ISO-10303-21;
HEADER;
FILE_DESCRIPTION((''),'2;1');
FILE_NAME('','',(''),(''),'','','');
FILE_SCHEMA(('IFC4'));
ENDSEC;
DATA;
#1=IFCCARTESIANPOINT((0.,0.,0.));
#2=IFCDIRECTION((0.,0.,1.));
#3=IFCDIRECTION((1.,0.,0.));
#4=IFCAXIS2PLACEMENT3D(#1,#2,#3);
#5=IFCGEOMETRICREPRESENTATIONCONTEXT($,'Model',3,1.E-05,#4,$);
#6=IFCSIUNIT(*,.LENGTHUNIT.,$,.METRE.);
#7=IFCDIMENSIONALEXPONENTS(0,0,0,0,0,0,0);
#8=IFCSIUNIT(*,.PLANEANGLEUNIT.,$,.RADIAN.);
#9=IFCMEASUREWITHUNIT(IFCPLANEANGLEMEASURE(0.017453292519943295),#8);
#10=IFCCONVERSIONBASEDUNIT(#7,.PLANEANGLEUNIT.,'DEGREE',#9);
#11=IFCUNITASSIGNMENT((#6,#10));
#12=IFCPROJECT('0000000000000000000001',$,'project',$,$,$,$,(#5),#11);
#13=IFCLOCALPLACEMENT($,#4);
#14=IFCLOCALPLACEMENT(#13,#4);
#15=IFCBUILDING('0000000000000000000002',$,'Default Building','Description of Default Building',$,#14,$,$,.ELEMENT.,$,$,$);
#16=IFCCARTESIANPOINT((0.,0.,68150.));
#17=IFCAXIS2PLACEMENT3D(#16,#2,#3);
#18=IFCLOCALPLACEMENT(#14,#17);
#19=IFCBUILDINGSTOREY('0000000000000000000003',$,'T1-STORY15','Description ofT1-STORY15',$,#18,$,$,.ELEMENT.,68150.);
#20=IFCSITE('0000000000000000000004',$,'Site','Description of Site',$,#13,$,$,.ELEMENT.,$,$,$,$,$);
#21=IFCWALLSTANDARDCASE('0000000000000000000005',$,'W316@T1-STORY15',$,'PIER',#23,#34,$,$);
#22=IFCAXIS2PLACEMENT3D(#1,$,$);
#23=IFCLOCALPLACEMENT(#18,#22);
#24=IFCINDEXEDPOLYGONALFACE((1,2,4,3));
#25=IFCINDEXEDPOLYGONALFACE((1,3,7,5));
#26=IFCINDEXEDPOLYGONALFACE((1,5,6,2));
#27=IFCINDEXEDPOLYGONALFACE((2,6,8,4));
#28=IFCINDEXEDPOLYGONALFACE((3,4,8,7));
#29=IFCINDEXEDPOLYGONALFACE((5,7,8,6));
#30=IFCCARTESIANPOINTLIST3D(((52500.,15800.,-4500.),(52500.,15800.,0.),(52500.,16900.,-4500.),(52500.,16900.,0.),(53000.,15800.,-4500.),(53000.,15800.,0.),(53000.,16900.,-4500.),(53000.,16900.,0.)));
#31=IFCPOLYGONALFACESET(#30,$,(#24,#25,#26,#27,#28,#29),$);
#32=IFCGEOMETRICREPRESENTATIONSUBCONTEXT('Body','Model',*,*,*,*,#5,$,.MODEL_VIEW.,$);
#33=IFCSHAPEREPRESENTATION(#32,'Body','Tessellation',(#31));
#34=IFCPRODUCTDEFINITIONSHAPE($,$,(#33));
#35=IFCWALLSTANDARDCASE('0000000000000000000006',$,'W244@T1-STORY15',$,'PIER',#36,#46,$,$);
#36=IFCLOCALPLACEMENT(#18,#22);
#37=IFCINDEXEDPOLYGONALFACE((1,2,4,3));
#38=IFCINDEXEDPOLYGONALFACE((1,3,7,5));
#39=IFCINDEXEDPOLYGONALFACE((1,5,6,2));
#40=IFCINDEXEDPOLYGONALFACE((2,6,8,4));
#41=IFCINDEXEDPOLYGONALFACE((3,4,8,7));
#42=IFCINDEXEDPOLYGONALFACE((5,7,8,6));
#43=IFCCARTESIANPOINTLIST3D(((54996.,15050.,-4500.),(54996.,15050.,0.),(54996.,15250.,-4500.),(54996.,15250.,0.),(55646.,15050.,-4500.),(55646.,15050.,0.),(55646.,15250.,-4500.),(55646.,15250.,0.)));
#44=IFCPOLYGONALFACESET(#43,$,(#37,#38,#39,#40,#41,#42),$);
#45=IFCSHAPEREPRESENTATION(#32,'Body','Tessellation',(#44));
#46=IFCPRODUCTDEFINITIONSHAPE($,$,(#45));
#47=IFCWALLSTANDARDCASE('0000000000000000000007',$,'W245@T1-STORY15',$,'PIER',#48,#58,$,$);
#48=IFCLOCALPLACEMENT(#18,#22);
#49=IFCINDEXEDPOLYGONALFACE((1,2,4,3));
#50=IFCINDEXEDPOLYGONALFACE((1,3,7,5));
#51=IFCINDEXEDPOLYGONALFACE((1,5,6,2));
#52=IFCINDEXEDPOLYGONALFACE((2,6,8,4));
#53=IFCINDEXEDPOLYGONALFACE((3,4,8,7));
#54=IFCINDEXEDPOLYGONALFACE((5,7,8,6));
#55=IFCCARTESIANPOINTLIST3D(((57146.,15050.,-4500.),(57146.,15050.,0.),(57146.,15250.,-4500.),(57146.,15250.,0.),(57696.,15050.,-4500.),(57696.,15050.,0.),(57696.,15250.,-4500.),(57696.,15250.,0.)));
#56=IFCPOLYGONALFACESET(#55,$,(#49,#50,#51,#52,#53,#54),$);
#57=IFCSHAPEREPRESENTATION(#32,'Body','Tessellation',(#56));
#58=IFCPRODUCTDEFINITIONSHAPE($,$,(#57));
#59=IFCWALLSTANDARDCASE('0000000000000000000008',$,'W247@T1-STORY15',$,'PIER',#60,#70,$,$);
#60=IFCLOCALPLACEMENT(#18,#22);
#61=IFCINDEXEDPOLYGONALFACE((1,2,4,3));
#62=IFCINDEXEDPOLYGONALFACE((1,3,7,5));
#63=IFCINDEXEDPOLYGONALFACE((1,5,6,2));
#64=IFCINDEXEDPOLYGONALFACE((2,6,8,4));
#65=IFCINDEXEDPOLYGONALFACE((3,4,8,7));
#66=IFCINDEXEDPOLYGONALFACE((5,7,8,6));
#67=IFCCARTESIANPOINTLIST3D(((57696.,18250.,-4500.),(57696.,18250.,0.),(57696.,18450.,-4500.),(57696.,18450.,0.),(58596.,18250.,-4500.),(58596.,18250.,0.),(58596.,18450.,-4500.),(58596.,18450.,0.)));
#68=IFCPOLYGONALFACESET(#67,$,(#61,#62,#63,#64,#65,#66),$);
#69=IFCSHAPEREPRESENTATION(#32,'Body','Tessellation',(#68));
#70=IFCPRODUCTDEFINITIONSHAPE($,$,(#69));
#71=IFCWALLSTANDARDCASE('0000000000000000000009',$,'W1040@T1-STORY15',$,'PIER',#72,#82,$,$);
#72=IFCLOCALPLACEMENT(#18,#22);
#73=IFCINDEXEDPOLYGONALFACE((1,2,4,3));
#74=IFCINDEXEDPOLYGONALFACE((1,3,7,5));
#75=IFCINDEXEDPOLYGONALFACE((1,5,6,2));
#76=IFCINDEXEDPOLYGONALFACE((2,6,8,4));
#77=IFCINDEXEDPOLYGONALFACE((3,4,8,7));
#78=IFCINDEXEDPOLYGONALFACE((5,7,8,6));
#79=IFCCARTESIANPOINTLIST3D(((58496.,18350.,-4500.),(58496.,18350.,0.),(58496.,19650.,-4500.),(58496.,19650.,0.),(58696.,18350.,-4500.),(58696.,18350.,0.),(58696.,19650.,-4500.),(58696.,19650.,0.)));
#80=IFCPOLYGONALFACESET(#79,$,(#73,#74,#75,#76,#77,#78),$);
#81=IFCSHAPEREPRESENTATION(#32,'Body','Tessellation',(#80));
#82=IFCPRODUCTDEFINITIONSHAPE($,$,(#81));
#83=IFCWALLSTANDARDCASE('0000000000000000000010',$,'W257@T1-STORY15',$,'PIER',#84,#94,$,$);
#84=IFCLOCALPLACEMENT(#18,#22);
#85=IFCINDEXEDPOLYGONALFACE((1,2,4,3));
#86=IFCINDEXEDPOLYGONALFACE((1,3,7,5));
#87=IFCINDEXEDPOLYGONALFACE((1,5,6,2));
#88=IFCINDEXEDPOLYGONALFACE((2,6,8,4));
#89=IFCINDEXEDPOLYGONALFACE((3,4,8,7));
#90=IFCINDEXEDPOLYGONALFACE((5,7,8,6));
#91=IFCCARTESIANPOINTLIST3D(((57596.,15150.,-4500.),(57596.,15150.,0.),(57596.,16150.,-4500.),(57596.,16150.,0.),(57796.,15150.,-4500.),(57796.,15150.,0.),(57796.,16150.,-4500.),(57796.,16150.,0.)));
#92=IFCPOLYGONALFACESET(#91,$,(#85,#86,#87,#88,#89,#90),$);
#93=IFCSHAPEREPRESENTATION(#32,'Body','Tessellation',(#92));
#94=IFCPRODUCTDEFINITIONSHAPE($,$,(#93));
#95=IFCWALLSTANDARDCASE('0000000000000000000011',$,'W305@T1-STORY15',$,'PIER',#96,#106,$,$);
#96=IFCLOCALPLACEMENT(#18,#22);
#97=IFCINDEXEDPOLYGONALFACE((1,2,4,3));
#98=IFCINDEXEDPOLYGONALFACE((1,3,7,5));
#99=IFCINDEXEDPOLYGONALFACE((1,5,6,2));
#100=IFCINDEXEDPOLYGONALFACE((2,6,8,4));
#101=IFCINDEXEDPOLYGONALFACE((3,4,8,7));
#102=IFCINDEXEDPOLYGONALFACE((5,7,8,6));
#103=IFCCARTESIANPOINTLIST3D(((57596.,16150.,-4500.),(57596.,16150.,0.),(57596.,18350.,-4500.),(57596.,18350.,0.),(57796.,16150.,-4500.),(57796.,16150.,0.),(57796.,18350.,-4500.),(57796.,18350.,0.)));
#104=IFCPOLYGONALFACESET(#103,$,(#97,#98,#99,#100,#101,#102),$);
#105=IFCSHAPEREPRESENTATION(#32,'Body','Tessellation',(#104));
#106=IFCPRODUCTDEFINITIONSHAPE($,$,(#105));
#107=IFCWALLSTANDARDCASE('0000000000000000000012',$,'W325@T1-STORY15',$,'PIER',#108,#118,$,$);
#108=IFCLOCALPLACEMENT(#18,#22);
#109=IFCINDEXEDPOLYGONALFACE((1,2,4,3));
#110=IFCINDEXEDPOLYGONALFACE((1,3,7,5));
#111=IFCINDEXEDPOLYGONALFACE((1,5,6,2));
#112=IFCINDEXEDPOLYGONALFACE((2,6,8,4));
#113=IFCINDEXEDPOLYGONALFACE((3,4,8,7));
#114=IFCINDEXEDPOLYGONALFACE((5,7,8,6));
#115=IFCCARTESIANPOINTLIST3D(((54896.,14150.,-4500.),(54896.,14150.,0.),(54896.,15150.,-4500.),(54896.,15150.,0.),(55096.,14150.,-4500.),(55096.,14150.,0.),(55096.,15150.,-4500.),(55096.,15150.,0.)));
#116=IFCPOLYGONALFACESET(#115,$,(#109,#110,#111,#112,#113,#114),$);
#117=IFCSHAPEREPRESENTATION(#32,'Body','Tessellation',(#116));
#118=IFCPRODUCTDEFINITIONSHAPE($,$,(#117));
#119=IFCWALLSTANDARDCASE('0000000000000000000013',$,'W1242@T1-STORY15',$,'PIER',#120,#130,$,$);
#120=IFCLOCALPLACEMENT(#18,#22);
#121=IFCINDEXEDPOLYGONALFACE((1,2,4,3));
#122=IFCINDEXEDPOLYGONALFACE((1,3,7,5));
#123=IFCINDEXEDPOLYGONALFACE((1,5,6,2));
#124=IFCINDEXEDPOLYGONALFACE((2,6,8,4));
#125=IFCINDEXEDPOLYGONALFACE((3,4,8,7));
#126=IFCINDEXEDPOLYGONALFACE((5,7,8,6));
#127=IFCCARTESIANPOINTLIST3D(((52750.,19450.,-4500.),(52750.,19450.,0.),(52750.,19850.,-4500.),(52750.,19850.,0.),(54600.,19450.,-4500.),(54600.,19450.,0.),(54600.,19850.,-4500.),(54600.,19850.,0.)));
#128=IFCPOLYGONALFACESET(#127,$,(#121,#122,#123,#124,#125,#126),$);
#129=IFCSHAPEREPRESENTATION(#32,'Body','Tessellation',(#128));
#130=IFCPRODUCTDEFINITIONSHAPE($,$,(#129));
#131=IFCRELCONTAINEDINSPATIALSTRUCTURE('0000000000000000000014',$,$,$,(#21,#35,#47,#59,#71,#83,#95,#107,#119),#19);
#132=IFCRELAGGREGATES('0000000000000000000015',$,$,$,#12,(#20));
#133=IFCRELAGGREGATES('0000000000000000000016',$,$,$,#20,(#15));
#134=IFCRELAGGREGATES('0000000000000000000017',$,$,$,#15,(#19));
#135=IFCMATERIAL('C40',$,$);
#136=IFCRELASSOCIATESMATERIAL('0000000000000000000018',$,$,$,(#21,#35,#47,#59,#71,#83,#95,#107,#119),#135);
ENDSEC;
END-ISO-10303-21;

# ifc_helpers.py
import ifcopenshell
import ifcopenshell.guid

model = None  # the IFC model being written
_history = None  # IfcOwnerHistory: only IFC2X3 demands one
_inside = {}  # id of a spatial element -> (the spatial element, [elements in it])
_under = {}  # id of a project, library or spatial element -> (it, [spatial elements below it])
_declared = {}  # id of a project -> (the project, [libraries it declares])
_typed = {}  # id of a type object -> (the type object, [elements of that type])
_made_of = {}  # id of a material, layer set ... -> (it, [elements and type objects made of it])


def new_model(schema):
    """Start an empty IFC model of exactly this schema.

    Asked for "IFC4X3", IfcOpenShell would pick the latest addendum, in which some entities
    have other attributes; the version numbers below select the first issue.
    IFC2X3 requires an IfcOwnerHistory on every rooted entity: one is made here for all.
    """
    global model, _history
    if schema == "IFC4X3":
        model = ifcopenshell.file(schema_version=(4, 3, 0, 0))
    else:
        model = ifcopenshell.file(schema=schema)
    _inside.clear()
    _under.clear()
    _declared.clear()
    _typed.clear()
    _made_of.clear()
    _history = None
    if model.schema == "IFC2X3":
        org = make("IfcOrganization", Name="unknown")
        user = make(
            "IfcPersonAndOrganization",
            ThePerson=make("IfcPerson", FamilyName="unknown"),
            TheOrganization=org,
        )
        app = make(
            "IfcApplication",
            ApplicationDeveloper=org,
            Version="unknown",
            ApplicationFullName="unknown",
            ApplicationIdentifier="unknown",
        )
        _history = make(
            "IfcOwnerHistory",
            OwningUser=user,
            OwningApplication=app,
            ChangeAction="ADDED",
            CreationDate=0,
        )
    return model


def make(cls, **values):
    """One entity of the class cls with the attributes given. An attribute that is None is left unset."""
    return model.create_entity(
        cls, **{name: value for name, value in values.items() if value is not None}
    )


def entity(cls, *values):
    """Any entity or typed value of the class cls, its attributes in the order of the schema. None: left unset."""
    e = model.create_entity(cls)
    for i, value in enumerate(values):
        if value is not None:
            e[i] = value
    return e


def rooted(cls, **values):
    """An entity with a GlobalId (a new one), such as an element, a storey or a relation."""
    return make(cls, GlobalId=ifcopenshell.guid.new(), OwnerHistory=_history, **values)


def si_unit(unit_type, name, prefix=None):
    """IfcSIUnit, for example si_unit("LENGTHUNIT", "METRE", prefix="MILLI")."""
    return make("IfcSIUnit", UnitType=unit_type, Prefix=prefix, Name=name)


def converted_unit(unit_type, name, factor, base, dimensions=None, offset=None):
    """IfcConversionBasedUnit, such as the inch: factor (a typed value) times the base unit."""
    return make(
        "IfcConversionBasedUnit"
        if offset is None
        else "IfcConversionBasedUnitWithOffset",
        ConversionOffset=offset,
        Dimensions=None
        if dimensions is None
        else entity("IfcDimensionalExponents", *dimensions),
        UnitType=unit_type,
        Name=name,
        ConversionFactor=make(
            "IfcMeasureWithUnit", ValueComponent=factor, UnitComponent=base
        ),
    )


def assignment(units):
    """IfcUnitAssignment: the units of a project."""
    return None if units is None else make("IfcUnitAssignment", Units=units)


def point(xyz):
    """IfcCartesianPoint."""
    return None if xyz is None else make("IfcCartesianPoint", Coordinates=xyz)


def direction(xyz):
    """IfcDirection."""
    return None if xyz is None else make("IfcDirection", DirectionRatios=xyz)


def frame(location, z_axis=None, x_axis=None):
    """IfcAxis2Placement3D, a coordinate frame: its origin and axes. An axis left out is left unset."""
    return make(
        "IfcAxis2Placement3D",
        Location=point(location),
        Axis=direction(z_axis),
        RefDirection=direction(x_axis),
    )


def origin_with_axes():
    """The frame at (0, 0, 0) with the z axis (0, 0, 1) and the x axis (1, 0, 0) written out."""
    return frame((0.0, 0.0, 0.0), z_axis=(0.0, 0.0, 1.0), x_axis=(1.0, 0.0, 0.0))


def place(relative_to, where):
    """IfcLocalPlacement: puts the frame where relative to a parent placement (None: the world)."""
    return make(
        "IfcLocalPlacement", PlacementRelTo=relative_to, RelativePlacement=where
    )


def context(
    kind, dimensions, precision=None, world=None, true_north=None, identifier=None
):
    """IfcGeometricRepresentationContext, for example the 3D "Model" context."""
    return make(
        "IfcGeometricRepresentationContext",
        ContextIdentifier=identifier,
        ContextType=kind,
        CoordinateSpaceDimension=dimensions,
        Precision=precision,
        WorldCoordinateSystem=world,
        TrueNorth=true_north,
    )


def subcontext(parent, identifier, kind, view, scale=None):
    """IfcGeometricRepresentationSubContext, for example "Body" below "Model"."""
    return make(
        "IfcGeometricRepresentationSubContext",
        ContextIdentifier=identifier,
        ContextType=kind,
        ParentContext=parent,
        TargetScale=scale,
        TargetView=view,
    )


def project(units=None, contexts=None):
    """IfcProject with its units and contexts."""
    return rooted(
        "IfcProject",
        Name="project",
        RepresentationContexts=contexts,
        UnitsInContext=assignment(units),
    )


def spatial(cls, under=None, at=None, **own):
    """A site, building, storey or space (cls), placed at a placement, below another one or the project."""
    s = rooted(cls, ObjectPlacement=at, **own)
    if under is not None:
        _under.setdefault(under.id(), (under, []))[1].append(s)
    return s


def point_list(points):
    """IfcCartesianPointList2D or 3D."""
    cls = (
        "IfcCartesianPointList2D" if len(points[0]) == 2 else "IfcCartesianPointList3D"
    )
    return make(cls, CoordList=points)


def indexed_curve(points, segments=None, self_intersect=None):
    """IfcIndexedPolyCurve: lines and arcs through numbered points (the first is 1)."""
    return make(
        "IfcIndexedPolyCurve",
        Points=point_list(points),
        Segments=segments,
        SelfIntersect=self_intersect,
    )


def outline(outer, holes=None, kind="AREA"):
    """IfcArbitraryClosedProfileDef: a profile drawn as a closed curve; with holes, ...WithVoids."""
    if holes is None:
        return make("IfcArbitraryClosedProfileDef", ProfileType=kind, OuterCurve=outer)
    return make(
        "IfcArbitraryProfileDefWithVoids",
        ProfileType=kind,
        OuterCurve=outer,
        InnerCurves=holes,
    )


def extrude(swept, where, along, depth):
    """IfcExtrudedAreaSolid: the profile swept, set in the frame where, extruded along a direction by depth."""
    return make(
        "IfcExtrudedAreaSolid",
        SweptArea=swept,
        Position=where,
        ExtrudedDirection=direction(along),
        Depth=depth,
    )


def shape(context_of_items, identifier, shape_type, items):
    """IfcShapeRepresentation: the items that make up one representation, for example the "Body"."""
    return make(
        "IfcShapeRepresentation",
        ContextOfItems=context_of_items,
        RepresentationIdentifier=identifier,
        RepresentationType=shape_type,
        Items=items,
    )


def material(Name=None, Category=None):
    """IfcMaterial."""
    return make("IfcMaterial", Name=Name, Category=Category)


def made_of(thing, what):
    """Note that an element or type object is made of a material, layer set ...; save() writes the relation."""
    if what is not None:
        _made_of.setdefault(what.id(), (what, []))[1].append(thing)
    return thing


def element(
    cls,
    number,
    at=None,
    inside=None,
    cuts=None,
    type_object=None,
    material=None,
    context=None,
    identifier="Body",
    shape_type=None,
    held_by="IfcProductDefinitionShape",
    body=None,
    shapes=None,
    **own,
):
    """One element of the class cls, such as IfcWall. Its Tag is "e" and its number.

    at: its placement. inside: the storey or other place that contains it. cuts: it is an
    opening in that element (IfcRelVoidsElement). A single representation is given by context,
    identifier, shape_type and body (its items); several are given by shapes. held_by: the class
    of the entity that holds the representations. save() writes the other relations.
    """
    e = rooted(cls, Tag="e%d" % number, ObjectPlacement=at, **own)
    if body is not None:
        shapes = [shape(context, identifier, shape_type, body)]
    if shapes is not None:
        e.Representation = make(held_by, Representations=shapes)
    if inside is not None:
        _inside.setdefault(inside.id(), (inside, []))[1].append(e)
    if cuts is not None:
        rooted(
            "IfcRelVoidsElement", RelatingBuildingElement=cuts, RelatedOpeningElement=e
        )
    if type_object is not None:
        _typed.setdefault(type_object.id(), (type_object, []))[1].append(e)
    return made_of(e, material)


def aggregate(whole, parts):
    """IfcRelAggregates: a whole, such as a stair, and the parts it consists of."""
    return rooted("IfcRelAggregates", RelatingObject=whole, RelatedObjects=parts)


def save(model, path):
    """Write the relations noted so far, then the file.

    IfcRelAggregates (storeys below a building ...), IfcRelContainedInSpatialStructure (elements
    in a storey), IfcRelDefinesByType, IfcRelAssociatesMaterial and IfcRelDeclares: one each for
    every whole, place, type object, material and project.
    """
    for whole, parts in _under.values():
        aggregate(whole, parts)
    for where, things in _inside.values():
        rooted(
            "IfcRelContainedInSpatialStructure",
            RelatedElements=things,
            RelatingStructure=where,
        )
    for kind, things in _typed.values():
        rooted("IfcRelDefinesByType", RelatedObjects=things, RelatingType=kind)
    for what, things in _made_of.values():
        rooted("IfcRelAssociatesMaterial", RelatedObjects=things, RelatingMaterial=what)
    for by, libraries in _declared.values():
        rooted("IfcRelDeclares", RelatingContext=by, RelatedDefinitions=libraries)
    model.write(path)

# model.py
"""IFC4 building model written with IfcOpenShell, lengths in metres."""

from ifc_helpers import new_model, entity, si_unit, converted_unit, frame, origin_with_axes, place, context, subcontext, project, spatial, indexed_curve, outline, extrude, material, element, save


model = new_model("IFC4")

# Units and contexts
model_context = context("Model", 3, precision=1e-05, world=origin_with_axes())
body_context = subcontext(model_context, "Body", "Model", "MODEL_VIEW")
ifc_project = project(units=[si_unit("LENGTHUNIT", "METRE"), converted_unit("PLANEANGLEUNIT", "DEGREE", entity("IfcPlaneAngleMeasure", 0.017453292519943295), si_unit("PLANEANGLEUNIT", "RADIAN"), dimensions=[0, 0, 0, 0, 0, 0, 0])], contexts=[model_context])

# Site, building, storey
site_placement = place(None, origin_with_axes())
site = spatial("IfcSite", under=ifc_project, at=site_placement, Name="Site", Description="Description of Site", CompositionType="ELEMENT")
building_placement = place(site_placement, origin_with_axes())
building = spatial("IfcBuilding", under=site, at=building_placement, Name="Default Building", Description="Description of Default Building", CompositionType="ELEMENT")
storey_placement = place(building_placement, frame((0.0, 0.0, 68150.0), z_axis=(0.0, 0.0, 1.0), x_axis=(1.0, 0.0, 0.0)))
storey = spatial("IfcBuildingStorey", under=building, at=storey_placement, Name="T1-STORY15", Description="Description ofT1-STORY15", CompositionType="ELEMENT", Elevation=68150.0)

# Walls
ifc_material_1 = material(Name="C40")
wall_1_placement = place(storey_placement, frame((52750.0, 15800.0, -4500.0), z_axis=(0.0, 0.0, 1.0), x_axis=(0.0, 1.0, 0.0)))
element("IfcWallStandardCase", 1, at=wall_1_placement, inside=storey, material=ifc_material_1, Name="W316@T1-STORY15", ObjectType="PIER", context=body_context, shape_type="SweptSolid", body=[
    extrude(outline(indexed_curve([(0.0, -250.0), (0.0, 250.0), (1100.0, 250.0), (1100.0, -250.0), (0.0, -250.0)], self_intersect=False)), origin_with_axes(), (0.0, 0.0, 1.0), 4500.0),
])
wall_2_placement = place(storey_placement, frame((54996.0, 15150.0, -4500.0), z_axis=(0.0, 0.0, 1.0), x_axis=(1.0, 0.0, 0.0)))
element("IfcWallStandardCase", 2, at=wall_2_placement, inside=storey, material=ifc_material_1, Name="W244@T1-STORY15", ObjectType="PIER", context=body_context, shape_type="SweptSolid", body=[
    extrude(outline(indexed_curve([(0.0, -100.0), (0.0, 100.0), (650.0, 100.0), (650.0, -100.0), (0.0, -100.0)], self_intersect=False)), origin_with_axes(), (0.0, 0.0, 1.0), 4500.0),
])
wall_3_placement = place(storey_placement, frame((57146.0, 15150.0, -4500.0), z_axis=(0.0, 0.0, 1.0), x_axis=(1.0, 0.0, 0.0)))
element("IfcWallStandardCase", 3, at=wall_3_placement, inside=storey, material=ifc_material_1, Name="W245@T1-STORY15", ObjectType="PIER", context=body_context, shape_type="SweptSolid", body=[
    extrude(outline(indexed_curve([(0.0, -100.0), (0.0, 100.0), (550.0, 100.0), (550.0, -100.0), (0.0, -100.0)], self_intersect=False)), origin_with_axes(), (0.0, 0.0, 1.0), 4500.0),
])
wall_4_placement = place(storey_placement, frame((57696.0, 18350.0, -4500.0), z_axis=(0.0, 0.0, 1.0), x_axis=(1.0, 0.0, 0.0)))
element("IfcWallStandardCase", 4, at=wall_4_placement, inside=storey, material=ifc_material_1, Name="W247@T1-STORY15", ObjectType="PIER", context=body_context, shape_type="SweptSolid", body=[
    extrude(outline(indexed_curve([(0.0, -100.0), (0.0, 100.0), (900.0, 100.0), (900.0, -100.0), (0.0, -100.0)], self_intersect=False)), origin_with_axes(), (0.0, 0.0, 1.0), 4500.0),
])
wall_5_placement = place(storey_placement, frame((58596.0, 18350.0, -4500.0), z_axis=(0.0, 0.0, 1.0), x_axis=(0.0, 1.0, 0.0)))
element("IfcWallStandardCase", 5, at=wall_5_placement, inside=storey, material=ifc_material_1, Name="W1040@T1-STORY15", ObjectType="PIER", context=body_context, shape_type="SweptSolid", body=[
    extrude(outline(indexed_curve([(0.0, -100.0), (0.0, 100.0), (1300.0, 100.0), (1300.0, -100.0), (0.0, -100.0)], self_intersect=False)), origin_with_axes(), (0.0, 0.0, 1.0), 4500.0),
])
wall_6_placement = place(storey_placement, frame((57696.0, 15150.0, -4500.0), z_axis=(0.0, 0.0, 1.0), x_axis=(0.0, 1.0, 0.0)))
element("IfcWallStandardCase", 6, at=wall_6_placement, inside=storey, material=ifc_material_1, Name="W257@T1-STORY15", ObjectType="PIER", context=body_context, shape_type="SweptSolid", body=[
    extrude(outline(indexed_curve([(0.0, -100.0), (0.0, 100.0), (1000.0, 100.0), (1000.0, -100.0), (0.0, -100.0)], self_intersect=False)), origin_with_axes(), (0.0, 0.0, 1.0), 4500.0),
])
wall_7_placement = place(storey_placement, frame((57696.0, 16150.0, -4500.0), z_axis=(0.0, 0.0, 1.0), x_axis=(0.0, 1.0, 0.0)))
element("IfcWallStandardCase", 7, at=wall_7_placement, inside=storey, material=ifc_material_1, Name="W305@T1-STORY15", ObjectType="PIER", context=body_context, shape_type="SweptSolid", body=[
    extrude(outline(indexed_curve([(0.0, -100.0), (0.0, 100.0), (2200.0, 100.0), (2200.0, -100.0), (0.0, -100.0)], self_intersect=False)), origin_with_axes(), (0.0, 0.0, 1.0), 4500.0),
])
wall_8_placement = place(storey_placement, frame((54996.0, 14150.0, -4500.0), z_axis=(0.0, 0.0, 1.0), x_axis=(0.0, 1.0, 0.0)))
element("IfcWallStandardCase", 8, at=wall_8_placement, inside=storey, material=ifc_material_1, Name="W325@T1-STORY15", ObjectType="PIER", context=body_context, shape_type="SweptSolid", body=[
    extrude(outline(indexed_curve([(0.0, -100.0), (0.0, 100.0), (1000.0, 100.0), (1000.0, -100.0), (0.0, -100.0)], self_intersect=False)), origin_with_axes(), (0.0, 0.0, 1.0), 4500.0),
])
wall_9_placement = place(storey_placement, frame((52750.0, 19650.0, -4500.0), z_axis=(0.0, 0.0, 1.0), x_axis=(1.0, 0.0, 0.0)))
element("IfcWallStandardCase", 9, at=wall_9_placement, inside=storey, material=ifc_material_1, Name="W1242@T1-STORY15", ObjectType="PIER", context=body_context, shape_type="SweptSolid", body=[
    extrude(outline(indexed_curve([(0.0, -200.0), (0.0, 200.0), (1850.0, 200.0), (1850.0, -200.0), (0.0, -200.0)], self_intersect=False)), origin_with_axes(), (0.0, 0.0, 1.0), 4500.0),
])

save(model, "model.ifc")
